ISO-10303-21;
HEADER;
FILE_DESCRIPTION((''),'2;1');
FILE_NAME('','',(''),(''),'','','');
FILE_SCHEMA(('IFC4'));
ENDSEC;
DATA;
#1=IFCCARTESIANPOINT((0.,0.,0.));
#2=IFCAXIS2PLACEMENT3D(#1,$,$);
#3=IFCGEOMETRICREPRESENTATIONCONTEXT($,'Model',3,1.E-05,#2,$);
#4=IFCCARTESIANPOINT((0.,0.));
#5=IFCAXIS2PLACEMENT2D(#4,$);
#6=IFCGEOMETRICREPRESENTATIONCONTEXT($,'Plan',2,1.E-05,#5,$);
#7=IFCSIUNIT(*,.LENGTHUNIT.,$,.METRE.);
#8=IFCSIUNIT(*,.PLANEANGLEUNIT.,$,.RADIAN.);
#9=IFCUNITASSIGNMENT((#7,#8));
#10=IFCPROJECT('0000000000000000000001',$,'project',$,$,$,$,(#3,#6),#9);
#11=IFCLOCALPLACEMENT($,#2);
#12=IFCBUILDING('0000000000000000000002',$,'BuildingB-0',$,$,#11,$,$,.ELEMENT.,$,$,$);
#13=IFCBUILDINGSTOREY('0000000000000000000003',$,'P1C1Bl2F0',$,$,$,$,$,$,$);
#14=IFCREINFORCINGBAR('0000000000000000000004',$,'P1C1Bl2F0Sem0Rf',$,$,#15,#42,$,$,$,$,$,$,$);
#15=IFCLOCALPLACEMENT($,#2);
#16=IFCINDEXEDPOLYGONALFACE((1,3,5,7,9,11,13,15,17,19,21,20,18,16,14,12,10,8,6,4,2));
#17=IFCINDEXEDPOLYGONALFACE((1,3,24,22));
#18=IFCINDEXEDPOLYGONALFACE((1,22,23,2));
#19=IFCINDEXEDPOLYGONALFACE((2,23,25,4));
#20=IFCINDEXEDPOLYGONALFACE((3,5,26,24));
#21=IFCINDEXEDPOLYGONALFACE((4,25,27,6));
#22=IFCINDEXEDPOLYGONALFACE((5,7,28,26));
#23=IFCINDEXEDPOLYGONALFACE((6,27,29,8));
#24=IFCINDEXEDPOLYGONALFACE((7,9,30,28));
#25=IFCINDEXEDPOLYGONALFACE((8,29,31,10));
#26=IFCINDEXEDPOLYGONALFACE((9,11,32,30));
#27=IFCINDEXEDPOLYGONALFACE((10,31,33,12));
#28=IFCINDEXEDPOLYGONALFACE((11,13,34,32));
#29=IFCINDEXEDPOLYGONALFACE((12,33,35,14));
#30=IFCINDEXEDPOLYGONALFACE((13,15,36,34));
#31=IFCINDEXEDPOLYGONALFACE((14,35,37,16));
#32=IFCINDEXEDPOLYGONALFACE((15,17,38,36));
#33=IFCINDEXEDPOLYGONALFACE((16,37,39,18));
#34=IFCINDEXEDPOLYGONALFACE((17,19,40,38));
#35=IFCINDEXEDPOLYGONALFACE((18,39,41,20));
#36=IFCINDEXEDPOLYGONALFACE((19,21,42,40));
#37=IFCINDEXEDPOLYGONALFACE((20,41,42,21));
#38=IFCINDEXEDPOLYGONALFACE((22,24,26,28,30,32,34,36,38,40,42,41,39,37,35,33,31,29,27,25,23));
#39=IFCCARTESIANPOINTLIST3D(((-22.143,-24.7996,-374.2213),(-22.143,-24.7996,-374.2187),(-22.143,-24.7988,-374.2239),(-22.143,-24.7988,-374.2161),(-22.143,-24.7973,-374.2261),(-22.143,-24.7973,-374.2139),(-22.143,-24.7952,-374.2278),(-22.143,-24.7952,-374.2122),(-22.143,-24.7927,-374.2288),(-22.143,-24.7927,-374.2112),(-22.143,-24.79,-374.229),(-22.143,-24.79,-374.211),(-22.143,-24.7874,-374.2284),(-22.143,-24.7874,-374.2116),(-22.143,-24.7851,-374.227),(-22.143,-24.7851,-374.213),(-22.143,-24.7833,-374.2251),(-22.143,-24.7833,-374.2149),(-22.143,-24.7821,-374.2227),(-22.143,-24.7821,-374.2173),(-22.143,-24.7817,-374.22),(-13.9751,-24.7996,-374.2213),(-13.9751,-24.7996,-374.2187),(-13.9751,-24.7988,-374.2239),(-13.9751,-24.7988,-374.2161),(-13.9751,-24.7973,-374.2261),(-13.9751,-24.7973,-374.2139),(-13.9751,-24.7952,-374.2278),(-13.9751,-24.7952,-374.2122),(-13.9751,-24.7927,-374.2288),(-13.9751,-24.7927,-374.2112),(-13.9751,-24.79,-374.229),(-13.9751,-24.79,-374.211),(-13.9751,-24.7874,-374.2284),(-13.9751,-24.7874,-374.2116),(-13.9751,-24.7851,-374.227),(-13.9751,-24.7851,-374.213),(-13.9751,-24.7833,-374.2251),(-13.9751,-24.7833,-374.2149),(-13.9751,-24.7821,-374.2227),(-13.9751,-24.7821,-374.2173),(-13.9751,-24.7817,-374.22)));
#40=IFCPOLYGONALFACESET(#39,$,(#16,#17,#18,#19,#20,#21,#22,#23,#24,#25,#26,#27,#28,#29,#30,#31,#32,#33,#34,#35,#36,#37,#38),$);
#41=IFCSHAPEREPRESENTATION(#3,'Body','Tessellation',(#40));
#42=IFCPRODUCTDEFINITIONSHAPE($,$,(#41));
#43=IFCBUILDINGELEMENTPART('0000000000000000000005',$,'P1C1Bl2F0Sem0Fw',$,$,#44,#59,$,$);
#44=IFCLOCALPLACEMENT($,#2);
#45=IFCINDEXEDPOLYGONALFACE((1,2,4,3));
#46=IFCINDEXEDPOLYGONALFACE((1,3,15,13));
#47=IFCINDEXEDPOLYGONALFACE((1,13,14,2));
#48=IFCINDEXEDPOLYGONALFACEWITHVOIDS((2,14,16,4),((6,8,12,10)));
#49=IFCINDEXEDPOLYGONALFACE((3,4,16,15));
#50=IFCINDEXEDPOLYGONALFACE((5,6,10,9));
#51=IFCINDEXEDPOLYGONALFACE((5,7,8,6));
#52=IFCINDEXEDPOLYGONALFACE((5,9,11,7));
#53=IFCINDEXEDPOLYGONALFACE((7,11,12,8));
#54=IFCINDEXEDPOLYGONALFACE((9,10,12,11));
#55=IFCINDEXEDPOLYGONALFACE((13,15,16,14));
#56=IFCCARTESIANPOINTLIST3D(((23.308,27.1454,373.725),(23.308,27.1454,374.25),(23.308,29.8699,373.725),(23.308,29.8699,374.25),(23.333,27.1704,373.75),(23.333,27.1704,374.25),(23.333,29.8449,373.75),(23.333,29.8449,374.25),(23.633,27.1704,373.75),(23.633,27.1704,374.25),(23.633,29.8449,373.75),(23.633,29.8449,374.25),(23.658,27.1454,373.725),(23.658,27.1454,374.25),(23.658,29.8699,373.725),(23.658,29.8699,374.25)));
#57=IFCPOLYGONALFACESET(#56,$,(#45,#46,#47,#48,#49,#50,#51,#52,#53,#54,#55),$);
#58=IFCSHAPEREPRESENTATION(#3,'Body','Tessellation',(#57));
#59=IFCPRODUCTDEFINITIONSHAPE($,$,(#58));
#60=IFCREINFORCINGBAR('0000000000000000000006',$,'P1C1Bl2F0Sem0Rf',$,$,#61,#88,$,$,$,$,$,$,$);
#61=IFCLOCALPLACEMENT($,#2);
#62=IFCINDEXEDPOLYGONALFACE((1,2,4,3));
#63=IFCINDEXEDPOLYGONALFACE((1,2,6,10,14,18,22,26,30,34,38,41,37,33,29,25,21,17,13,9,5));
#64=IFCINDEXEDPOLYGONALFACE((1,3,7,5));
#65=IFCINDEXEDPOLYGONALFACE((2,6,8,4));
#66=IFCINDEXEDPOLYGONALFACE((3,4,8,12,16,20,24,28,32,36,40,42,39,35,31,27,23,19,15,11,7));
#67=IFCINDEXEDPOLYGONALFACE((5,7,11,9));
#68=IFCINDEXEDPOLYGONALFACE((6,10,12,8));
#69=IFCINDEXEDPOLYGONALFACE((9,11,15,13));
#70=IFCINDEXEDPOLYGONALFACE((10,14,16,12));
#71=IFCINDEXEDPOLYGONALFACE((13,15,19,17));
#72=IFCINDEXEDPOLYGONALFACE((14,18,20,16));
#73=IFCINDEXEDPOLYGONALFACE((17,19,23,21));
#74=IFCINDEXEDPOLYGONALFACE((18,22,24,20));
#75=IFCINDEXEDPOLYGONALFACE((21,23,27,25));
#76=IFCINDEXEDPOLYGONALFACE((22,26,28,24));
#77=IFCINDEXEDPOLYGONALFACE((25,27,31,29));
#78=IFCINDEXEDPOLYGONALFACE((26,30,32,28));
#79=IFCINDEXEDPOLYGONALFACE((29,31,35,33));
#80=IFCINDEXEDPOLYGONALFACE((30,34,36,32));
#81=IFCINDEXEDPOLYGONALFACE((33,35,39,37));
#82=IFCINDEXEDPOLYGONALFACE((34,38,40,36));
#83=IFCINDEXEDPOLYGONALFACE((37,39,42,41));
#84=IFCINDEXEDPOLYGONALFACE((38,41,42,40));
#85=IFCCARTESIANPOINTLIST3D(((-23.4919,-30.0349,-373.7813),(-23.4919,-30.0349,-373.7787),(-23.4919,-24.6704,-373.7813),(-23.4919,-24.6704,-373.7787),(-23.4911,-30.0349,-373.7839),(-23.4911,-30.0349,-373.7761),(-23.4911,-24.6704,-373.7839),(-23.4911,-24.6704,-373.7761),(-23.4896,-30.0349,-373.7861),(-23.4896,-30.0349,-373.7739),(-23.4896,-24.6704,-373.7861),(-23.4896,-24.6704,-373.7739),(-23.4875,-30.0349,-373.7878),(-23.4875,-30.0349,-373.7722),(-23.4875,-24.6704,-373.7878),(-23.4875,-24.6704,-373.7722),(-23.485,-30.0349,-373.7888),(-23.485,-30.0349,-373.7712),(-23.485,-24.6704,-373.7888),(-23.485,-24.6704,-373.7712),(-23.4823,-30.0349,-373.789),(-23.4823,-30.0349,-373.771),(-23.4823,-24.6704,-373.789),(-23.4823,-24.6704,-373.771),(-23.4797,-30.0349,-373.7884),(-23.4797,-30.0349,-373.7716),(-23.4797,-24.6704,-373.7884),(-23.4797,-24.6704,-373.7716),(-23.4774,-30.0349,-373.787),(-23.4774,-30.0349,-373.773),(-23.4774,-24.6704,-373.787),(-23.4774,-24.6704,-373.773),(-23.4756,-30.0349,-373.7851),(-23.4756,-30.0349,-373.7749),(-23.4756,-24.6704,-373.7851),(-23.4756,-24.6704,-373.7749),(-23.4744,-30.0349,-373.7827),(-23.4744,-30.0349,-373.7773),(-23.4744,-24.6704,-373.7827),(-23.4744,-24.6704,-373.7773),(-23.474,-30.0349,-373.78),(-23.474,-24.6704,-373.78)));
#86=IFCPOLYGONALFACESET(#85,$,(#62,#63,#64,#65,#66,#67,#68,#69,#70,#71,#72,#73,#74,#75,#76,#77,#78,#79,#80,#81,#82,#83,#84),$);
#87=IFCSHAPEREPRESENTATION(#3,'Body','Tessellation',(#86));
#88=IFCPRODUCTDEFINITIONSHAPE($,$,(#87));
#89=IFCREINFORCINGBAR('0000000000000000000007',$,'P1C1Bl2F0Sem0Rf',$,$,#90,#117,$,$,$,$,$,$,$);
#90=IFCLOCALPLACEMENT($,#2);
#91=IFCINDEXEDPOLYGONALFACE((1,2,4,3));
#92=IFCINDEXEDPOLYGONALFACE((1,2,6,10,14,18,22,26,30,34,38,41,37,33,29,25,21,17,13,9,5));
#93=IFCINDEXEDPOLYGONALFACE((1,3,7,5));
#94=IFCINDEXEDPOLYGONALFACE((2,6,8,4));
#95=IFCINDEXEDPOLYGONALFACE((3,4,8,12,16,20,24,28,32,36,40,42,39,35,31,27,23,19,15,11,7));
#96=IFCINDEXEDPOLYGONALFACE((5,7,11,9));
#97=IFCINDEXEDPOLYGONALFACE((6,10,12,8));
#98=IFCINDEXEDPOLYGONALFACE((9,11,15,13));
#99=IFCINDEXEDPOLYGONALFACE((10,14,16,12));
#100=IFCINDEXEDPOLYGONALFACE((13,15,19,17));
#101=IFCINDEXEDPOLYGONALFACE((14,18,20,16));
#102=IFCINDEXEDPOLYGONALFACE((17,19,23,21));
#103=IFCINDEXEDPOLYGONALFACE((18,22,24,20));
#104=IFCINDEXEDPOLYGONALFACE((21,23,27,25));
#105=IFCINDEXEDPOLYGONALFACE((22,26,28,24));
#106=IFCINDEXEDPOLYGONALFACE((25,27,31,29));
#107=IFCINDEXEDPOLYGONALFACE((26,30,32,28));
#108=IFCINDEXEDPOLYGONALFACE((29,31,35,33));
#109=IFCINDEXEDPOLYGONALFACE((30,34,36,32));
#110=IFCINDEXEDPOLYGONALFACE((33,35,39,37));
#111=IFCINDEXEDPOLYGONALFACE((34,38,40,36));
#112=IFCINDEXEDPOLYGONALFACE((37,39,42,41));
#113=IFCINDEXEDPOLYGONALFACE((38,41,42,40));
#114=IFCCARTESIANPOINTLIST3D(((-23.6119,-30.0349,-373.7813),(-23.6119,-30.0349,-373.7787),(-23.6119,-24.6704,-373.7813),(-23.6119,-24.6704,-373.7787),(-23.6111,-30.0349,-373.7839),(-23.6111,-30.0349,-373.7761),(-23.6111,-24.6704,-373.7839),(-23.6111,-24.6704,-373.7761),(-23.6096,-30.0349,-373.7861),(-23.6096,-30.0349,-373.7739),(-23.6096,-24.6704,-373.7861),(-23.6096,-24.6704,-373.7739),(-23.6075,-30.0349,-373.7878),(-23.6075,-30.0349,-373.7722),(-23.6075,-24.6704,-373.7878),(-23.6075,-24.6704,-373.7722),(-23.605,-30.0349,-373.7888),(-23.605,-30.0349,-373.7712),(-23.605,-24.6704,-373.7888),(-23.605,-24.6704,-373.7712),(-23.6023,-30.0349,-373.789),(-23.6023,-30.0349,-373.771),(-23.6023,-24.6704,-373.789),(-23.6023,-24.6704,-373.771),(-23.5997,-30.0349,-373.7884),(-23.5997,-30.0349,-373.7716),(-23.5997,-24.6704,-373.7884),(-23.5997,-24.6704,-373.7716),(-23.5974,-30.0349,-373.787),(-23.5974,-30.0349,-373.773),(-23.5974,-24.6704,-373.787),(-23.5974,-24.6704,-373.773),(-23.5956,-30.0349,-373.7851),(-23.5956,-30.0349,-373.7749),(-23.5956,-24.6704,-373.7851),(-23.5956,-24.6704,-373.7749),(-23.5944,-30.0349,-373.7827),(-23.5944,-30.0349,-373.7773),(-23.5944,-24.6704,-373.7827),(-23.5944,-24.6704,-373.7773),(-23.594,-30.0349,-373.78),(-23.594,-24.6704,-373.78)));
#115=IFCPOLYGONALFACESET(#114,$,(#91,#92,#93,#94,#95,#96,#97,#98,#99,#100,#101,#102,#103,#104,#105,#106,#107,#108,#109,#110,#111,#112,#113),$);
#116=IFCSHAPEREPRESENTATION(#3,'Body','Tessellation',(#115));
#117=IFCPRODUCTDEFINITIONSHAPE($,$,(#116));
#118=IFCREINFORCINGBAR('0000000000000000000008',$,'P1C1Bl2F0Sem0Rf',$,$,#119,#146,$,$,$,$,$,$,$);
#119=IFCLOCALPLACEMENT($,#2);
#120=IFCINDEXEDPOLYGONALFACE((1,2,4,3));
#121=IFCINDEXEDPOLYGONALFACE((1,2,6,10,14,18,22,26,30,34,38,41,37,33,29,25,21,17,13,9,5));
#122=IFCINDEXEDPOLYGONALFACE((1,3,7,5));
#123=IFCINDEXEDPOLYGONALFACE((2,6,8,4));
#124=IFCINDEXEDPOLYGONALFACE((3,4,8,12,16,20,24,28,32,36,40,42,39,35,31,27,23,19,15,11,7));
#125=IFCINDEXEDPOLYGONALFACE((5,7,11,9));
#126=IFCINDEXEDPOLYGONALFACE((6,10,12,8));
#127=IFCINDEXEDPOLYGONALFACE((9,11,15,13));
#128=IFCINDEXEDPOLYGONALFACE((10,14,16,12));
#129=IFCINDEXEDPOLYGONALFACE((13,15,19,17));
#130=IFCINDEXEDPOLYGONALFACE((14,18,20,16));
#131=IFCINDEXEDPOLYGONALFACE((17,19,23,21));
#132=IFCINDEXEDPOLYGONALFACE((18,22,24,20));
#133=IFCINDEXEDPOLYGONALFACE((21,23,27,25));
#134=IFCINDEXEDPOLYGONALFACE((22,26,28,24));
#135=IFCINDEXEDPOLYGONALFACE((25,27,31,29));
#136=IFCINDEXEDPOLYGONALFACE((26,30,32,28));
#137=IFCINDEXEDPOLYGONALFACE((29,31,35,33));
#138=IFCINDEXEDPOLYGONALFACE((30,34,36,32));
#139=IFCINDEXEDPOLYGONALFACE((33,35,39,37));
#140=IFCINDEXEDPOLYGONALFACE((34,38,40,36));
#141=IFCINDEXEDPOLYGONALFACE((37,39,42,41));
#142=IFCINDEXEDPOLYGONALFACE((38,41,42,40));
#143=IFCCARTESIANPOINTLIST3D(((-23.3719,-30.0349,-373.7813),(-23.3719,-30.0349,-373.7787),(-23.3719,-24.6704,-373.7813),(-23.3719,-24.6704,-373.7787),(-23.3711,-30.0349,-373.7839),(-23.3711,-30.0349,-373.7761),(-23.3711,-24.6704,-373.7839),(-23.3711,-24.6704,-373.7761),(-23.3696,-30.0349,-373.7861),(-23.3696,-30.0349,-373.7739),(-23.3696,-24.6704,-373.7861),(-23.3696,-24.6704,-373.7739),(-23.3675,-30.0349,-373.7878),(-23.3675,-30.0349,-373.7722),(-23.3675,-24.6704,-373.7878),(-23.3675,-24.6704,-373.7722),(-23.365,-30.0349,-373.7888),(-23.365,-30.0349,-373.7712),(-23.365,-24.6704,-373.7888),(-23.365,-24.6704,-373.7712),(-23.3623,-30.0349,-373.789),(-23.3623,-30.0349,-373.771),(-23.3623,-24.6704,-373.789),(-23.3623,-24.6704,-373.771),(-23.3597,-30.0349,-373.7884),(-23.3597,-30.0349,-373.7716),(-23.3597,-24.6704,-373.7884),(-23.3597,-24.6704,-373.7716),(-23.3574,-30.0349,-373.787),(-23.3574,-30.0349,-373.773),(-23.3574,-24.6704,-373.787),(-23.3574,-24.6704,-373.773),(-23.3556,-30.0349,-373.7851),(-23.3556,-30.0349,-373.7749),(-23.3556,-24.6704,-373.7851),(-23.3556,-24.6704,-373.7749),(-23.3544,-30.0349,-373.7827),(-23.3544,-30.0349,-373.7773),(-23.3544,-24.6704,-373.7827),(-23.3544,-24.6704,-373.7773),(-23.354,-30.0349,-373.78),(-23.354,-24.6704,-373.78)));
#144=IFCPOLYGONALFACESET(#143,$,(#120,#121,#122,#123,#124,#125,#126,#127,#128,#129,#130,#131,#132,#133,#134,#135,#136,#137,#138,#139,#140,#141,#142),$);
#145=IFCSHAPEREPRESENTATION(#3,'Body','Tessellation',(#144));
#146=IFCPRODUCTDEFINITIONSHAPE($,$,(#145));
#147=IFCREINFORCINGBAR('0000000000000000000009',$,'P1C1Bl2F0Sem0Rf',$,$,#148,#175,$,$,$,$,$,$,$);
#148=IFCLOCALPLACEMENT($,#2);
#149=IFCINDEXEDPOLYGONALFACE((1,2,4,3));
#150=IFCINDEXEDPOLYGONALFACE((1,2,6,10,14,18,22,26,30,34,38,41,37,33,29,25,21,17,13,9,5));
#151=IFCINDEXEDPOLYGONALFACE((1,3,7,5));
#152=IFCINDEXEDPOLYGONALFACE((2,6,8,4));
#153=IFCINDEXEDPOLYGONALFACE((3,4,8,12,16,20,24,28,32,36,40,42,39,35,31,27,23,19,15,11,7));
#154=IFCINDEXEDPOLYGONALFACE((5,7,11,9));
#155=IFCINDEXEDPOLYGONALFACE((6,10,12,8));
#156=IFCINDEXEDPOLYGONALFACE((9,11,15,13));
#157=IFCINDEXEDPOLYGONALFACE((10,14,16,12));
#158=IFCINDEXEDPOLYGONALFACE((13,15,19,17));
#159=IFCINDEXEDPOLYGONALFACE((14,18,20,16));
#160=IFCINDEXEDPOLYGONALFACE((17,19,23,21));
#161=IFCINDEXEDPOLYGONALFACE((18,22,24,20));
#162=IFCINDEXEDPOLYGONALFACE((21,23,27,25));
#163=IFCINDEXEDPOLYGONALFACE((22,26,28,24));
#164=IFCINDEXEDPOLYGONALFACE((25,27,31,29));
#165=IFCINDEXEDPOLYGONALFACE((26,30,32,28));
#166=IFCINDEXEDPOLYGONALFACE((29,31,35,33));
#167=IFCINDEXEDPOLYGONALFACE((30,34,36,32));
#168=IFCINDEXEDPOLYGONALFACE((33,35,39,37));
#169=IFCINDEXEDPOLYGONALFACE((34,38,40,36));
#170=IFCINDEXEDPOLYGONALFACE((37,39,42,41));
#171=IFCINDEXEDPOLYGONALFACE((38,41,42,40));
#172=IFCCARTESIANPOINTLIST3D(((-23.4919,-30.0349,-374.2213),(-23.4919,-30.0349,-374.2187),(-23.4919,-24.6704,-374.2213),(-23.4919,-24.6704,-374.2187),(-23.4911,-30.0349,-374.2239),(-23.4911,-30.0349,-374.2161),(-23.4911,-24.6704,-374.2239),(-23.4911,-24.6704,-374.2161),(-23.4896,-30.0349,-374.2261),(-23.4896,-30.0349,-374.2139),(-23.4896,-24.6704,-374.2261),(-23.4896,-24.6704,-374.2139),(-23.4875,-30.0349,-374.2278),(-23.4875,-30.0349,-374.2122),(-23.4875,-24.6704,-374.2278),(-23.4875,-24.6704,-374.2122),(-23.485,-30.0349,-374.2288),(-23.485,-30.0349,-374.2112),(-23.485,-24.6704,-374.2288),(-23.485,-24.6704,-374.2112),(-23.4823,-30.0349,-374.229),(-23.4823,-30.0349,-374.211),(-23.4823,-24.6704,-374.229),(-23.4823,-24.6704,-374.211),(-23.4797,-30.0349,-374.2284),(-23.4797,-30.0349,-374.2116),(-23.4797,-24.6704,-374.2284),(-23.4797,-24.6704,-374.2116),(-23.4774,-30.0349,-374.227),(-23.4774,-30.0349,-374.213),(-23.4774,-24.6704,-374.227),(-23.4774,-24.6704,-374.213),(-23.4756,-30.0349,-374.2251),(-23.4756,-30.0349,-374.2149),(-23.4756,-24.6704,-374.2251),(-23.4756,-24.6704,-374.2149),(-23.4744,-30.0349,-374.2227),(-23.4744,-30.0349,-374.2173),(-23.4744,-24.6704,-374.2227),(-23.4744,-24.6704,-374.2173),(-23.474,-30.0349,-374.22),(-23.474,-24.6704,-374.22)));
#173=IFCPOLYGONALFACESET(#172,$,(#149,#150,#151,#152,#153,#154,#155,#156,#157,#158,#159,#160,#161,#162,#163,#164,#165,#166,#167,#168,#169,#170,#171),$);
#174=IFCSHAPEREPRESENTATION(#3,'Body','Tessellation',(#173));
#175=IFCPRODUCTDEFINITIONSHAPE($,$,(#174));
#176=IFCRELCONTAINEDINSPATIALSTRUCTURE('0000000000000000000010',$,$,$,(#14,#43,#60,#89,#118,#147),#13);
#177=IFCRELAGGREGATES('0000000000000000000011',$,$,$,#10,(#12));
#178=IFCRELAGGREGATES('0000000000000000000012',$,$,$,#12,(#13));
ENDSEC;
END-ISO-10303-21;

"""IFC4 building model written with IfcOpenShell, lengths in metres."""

from ifc_helpers import new_model, entity, si_unit, origin, origin_2d, place, context, project, spatial, polyline, outline, extrude, element, save


model = new_model("IFC4")

# Units and contexts
model_context = context("Model", 3, precision=1e-05, world=origin())
plan_context = context("Plan", 2, precision=1e-05, world=origin_2d())
ifc_project = project(units=[si_unit("LENGTHUNIT", "METRE"), si_unit("PLANEANGLEUNIT", "RADIAN")], contexts=[model_context, plan_context])

# Building, storey
building_placement = place(None, origin())
building = spatial("IfcBuilding", under=ifc_project, at=building_placement, Name="BuildingB-0", CompositionType="ELEMENT")
storey = spatial("IfcBuildingStorey", under=building, Name="P1C1Bl2F0")

# Reinforcing bar
element("IfcReinforcingBar", 1, inside=storey, Name="P1C1Bl2F0Sem0Rf", context=model_context, shape_type="SweptSolid", body=[
    entity("IfcSurfaceCurveSweptAreaSolid", entity("IfcCircleProfileDef", "AREA", None, None, 0.009), None, entity("IfcPolyline", [entity("IfcCartesianPoint", [13.9751, 24.7907, 374.22]), entity("IfcCartesianPoint", [22.143, 24.7907, 374.22])]), None, None, entity("IfcPlane", entity("IfcAxis2Placement3D", entity("IfcCartesianPoint", [13.9751, 24.7907, 374.22]), entity("IfcDirection", [0.0, 0.0, 1.0]), entity("IfcDirection", [1.0, 0.0, 0.0])))),
])

# Building element part, opening
building_element_part_1 = element("IfcBuildingElementPart", 2, inside=storey, Name="P1C1Bl2F0Sem0Fw", context=model_context, shape_type="SweptSolid", body=[
    extrude(outline(polyline([(23.308, 27.1454, 373.725), (23.658, 27.1454, 373.725), (23.658, 29.8699, 373.725), (23.308, 29.8699, 373.725), (23.308, 27.1454, 373.725)])), None, (0.0, 0.0, 1.0), 0.525),
])
element("IfcOpeningElement", 3, inside=storey, cuts=building_element_part_1, context=model_context, shape_type="SweptSolid", body=[
    extrude(outline(polyline([(23.333, 27.1704, 373.75), (23.633, 27.1704, 373.75), (23.633, 29.8449, 373.75), (23.333, 29.8449, 373.75), (23.333, 27.1704, 373.75)])), None, (0.0, 0.0, 1.0), 0.5),
])

# Reinforcing bars
element("IfcReinforcingBar", 4, inside=storey, Name="P1C1Bl2F0Sem0Rf", context=model_context, shape_type="SweptSolid", body=[
    entity("IfcSurfaceCurveSweptAreaSolid", entity("IfcCircleProfileDef", "AREA", None, None, 0.009), None, entity("IfcPolyline", [entity("IfcCartesianPoint", [23.483, 24.6704, 373.78]), entity("IfcCartesianPoint", [23.483, 30.0349, 373.78])]), None, None, entity("IfcPlane", entity("IfcAxis2Placement3D", entity("IfcCartesianPoint", [23.483, 24.6704, 373.78]), entity("IfcDirection", [0.0, 0.0, 1.0]), entity("IfcDirection", [1.0, 0.0, 0.0])))),
])
element("IfcReinforcingBar", 5, inside=storey, Name="P1C1Bl2F0Sem0Rf", context=model_context, shape_type="SweptSolid", body=[
    entity("IfcSurfaceCurveSweptAreaSolid", entity("IfcCircleProfileDef", "AREA", None, None, 0.009), None, entity("IfcPolyline", [entity("IfcCartesianPoint", [23.603, 24.6704, 373.78]), entity("IfcCartesianPoint", [23.603, 30.0349, 373.78])]), None, None, entity("IfcPlane", entity("IfcAxis2Placement3D", entity("IfcCartesianPoint", [23.603, 24.6704, 373.78]), entity("IfcDirection", [0.0, 0.0, 1.0]), entity("IfcDirection", [1.0, 0.0, 0.0])))),
])
element("IfcReinforcingBar", 6, inside=storey, Name="P1C1Bl2F0Sem0Rf", context=model_context, shape_type="SweptSolid", body=[
    entity("IfcSurfaceCurveSweptAreaSolid", entity("IfcCircleProfileDef", "AREA", None, None, 0.009), None, entity("IfcPolyline", [entity("IfcCartesianPoint", [23.363, 24.6704, 373.78]), entity("IfcCartesianPoint", [23.363, 30.0349, 373.78])]), None, None, entity("IfcPlane", entity("IfcAxis2Placement3D", entity("IfcCartesianPoint", [23.363, 24.6704, 373.78]), entity("IfcDirection", [0.0, 0.0, 1.0]), entity("IfcDirection", [1.0, 0.0, 0.0])))),
])
element("IfcReinforcingBar", 7, inside=storey, Name="P1C1Bl2F0Sem0Rf", context=model_context, shape_type="SweptSolid", body=[
    entity("IfcSurfaceCurveSweptAreaSolid", entity("IfcCircleProfileDef", "AREA", None, None, 0.009), None, entity("IfcPolyline", [entity("IfcCartesianPoint", [23.483, 24.6704, 374.22]), entity("IfcCartesianPoint", [23.483, 30.0349, 374.22])]), None, None, entity("IfcPlane", entity("IfcAxis2Placement3D", entity("IfcCartesianPoint", [23.483, 24.6704, 374.22]), entity("IfcDirection", [0.0, 0.0, 1.0]), entity("IfcDirection", [1.0, 0.0, 0.0])))),
])

save(model, "model.ifc")
